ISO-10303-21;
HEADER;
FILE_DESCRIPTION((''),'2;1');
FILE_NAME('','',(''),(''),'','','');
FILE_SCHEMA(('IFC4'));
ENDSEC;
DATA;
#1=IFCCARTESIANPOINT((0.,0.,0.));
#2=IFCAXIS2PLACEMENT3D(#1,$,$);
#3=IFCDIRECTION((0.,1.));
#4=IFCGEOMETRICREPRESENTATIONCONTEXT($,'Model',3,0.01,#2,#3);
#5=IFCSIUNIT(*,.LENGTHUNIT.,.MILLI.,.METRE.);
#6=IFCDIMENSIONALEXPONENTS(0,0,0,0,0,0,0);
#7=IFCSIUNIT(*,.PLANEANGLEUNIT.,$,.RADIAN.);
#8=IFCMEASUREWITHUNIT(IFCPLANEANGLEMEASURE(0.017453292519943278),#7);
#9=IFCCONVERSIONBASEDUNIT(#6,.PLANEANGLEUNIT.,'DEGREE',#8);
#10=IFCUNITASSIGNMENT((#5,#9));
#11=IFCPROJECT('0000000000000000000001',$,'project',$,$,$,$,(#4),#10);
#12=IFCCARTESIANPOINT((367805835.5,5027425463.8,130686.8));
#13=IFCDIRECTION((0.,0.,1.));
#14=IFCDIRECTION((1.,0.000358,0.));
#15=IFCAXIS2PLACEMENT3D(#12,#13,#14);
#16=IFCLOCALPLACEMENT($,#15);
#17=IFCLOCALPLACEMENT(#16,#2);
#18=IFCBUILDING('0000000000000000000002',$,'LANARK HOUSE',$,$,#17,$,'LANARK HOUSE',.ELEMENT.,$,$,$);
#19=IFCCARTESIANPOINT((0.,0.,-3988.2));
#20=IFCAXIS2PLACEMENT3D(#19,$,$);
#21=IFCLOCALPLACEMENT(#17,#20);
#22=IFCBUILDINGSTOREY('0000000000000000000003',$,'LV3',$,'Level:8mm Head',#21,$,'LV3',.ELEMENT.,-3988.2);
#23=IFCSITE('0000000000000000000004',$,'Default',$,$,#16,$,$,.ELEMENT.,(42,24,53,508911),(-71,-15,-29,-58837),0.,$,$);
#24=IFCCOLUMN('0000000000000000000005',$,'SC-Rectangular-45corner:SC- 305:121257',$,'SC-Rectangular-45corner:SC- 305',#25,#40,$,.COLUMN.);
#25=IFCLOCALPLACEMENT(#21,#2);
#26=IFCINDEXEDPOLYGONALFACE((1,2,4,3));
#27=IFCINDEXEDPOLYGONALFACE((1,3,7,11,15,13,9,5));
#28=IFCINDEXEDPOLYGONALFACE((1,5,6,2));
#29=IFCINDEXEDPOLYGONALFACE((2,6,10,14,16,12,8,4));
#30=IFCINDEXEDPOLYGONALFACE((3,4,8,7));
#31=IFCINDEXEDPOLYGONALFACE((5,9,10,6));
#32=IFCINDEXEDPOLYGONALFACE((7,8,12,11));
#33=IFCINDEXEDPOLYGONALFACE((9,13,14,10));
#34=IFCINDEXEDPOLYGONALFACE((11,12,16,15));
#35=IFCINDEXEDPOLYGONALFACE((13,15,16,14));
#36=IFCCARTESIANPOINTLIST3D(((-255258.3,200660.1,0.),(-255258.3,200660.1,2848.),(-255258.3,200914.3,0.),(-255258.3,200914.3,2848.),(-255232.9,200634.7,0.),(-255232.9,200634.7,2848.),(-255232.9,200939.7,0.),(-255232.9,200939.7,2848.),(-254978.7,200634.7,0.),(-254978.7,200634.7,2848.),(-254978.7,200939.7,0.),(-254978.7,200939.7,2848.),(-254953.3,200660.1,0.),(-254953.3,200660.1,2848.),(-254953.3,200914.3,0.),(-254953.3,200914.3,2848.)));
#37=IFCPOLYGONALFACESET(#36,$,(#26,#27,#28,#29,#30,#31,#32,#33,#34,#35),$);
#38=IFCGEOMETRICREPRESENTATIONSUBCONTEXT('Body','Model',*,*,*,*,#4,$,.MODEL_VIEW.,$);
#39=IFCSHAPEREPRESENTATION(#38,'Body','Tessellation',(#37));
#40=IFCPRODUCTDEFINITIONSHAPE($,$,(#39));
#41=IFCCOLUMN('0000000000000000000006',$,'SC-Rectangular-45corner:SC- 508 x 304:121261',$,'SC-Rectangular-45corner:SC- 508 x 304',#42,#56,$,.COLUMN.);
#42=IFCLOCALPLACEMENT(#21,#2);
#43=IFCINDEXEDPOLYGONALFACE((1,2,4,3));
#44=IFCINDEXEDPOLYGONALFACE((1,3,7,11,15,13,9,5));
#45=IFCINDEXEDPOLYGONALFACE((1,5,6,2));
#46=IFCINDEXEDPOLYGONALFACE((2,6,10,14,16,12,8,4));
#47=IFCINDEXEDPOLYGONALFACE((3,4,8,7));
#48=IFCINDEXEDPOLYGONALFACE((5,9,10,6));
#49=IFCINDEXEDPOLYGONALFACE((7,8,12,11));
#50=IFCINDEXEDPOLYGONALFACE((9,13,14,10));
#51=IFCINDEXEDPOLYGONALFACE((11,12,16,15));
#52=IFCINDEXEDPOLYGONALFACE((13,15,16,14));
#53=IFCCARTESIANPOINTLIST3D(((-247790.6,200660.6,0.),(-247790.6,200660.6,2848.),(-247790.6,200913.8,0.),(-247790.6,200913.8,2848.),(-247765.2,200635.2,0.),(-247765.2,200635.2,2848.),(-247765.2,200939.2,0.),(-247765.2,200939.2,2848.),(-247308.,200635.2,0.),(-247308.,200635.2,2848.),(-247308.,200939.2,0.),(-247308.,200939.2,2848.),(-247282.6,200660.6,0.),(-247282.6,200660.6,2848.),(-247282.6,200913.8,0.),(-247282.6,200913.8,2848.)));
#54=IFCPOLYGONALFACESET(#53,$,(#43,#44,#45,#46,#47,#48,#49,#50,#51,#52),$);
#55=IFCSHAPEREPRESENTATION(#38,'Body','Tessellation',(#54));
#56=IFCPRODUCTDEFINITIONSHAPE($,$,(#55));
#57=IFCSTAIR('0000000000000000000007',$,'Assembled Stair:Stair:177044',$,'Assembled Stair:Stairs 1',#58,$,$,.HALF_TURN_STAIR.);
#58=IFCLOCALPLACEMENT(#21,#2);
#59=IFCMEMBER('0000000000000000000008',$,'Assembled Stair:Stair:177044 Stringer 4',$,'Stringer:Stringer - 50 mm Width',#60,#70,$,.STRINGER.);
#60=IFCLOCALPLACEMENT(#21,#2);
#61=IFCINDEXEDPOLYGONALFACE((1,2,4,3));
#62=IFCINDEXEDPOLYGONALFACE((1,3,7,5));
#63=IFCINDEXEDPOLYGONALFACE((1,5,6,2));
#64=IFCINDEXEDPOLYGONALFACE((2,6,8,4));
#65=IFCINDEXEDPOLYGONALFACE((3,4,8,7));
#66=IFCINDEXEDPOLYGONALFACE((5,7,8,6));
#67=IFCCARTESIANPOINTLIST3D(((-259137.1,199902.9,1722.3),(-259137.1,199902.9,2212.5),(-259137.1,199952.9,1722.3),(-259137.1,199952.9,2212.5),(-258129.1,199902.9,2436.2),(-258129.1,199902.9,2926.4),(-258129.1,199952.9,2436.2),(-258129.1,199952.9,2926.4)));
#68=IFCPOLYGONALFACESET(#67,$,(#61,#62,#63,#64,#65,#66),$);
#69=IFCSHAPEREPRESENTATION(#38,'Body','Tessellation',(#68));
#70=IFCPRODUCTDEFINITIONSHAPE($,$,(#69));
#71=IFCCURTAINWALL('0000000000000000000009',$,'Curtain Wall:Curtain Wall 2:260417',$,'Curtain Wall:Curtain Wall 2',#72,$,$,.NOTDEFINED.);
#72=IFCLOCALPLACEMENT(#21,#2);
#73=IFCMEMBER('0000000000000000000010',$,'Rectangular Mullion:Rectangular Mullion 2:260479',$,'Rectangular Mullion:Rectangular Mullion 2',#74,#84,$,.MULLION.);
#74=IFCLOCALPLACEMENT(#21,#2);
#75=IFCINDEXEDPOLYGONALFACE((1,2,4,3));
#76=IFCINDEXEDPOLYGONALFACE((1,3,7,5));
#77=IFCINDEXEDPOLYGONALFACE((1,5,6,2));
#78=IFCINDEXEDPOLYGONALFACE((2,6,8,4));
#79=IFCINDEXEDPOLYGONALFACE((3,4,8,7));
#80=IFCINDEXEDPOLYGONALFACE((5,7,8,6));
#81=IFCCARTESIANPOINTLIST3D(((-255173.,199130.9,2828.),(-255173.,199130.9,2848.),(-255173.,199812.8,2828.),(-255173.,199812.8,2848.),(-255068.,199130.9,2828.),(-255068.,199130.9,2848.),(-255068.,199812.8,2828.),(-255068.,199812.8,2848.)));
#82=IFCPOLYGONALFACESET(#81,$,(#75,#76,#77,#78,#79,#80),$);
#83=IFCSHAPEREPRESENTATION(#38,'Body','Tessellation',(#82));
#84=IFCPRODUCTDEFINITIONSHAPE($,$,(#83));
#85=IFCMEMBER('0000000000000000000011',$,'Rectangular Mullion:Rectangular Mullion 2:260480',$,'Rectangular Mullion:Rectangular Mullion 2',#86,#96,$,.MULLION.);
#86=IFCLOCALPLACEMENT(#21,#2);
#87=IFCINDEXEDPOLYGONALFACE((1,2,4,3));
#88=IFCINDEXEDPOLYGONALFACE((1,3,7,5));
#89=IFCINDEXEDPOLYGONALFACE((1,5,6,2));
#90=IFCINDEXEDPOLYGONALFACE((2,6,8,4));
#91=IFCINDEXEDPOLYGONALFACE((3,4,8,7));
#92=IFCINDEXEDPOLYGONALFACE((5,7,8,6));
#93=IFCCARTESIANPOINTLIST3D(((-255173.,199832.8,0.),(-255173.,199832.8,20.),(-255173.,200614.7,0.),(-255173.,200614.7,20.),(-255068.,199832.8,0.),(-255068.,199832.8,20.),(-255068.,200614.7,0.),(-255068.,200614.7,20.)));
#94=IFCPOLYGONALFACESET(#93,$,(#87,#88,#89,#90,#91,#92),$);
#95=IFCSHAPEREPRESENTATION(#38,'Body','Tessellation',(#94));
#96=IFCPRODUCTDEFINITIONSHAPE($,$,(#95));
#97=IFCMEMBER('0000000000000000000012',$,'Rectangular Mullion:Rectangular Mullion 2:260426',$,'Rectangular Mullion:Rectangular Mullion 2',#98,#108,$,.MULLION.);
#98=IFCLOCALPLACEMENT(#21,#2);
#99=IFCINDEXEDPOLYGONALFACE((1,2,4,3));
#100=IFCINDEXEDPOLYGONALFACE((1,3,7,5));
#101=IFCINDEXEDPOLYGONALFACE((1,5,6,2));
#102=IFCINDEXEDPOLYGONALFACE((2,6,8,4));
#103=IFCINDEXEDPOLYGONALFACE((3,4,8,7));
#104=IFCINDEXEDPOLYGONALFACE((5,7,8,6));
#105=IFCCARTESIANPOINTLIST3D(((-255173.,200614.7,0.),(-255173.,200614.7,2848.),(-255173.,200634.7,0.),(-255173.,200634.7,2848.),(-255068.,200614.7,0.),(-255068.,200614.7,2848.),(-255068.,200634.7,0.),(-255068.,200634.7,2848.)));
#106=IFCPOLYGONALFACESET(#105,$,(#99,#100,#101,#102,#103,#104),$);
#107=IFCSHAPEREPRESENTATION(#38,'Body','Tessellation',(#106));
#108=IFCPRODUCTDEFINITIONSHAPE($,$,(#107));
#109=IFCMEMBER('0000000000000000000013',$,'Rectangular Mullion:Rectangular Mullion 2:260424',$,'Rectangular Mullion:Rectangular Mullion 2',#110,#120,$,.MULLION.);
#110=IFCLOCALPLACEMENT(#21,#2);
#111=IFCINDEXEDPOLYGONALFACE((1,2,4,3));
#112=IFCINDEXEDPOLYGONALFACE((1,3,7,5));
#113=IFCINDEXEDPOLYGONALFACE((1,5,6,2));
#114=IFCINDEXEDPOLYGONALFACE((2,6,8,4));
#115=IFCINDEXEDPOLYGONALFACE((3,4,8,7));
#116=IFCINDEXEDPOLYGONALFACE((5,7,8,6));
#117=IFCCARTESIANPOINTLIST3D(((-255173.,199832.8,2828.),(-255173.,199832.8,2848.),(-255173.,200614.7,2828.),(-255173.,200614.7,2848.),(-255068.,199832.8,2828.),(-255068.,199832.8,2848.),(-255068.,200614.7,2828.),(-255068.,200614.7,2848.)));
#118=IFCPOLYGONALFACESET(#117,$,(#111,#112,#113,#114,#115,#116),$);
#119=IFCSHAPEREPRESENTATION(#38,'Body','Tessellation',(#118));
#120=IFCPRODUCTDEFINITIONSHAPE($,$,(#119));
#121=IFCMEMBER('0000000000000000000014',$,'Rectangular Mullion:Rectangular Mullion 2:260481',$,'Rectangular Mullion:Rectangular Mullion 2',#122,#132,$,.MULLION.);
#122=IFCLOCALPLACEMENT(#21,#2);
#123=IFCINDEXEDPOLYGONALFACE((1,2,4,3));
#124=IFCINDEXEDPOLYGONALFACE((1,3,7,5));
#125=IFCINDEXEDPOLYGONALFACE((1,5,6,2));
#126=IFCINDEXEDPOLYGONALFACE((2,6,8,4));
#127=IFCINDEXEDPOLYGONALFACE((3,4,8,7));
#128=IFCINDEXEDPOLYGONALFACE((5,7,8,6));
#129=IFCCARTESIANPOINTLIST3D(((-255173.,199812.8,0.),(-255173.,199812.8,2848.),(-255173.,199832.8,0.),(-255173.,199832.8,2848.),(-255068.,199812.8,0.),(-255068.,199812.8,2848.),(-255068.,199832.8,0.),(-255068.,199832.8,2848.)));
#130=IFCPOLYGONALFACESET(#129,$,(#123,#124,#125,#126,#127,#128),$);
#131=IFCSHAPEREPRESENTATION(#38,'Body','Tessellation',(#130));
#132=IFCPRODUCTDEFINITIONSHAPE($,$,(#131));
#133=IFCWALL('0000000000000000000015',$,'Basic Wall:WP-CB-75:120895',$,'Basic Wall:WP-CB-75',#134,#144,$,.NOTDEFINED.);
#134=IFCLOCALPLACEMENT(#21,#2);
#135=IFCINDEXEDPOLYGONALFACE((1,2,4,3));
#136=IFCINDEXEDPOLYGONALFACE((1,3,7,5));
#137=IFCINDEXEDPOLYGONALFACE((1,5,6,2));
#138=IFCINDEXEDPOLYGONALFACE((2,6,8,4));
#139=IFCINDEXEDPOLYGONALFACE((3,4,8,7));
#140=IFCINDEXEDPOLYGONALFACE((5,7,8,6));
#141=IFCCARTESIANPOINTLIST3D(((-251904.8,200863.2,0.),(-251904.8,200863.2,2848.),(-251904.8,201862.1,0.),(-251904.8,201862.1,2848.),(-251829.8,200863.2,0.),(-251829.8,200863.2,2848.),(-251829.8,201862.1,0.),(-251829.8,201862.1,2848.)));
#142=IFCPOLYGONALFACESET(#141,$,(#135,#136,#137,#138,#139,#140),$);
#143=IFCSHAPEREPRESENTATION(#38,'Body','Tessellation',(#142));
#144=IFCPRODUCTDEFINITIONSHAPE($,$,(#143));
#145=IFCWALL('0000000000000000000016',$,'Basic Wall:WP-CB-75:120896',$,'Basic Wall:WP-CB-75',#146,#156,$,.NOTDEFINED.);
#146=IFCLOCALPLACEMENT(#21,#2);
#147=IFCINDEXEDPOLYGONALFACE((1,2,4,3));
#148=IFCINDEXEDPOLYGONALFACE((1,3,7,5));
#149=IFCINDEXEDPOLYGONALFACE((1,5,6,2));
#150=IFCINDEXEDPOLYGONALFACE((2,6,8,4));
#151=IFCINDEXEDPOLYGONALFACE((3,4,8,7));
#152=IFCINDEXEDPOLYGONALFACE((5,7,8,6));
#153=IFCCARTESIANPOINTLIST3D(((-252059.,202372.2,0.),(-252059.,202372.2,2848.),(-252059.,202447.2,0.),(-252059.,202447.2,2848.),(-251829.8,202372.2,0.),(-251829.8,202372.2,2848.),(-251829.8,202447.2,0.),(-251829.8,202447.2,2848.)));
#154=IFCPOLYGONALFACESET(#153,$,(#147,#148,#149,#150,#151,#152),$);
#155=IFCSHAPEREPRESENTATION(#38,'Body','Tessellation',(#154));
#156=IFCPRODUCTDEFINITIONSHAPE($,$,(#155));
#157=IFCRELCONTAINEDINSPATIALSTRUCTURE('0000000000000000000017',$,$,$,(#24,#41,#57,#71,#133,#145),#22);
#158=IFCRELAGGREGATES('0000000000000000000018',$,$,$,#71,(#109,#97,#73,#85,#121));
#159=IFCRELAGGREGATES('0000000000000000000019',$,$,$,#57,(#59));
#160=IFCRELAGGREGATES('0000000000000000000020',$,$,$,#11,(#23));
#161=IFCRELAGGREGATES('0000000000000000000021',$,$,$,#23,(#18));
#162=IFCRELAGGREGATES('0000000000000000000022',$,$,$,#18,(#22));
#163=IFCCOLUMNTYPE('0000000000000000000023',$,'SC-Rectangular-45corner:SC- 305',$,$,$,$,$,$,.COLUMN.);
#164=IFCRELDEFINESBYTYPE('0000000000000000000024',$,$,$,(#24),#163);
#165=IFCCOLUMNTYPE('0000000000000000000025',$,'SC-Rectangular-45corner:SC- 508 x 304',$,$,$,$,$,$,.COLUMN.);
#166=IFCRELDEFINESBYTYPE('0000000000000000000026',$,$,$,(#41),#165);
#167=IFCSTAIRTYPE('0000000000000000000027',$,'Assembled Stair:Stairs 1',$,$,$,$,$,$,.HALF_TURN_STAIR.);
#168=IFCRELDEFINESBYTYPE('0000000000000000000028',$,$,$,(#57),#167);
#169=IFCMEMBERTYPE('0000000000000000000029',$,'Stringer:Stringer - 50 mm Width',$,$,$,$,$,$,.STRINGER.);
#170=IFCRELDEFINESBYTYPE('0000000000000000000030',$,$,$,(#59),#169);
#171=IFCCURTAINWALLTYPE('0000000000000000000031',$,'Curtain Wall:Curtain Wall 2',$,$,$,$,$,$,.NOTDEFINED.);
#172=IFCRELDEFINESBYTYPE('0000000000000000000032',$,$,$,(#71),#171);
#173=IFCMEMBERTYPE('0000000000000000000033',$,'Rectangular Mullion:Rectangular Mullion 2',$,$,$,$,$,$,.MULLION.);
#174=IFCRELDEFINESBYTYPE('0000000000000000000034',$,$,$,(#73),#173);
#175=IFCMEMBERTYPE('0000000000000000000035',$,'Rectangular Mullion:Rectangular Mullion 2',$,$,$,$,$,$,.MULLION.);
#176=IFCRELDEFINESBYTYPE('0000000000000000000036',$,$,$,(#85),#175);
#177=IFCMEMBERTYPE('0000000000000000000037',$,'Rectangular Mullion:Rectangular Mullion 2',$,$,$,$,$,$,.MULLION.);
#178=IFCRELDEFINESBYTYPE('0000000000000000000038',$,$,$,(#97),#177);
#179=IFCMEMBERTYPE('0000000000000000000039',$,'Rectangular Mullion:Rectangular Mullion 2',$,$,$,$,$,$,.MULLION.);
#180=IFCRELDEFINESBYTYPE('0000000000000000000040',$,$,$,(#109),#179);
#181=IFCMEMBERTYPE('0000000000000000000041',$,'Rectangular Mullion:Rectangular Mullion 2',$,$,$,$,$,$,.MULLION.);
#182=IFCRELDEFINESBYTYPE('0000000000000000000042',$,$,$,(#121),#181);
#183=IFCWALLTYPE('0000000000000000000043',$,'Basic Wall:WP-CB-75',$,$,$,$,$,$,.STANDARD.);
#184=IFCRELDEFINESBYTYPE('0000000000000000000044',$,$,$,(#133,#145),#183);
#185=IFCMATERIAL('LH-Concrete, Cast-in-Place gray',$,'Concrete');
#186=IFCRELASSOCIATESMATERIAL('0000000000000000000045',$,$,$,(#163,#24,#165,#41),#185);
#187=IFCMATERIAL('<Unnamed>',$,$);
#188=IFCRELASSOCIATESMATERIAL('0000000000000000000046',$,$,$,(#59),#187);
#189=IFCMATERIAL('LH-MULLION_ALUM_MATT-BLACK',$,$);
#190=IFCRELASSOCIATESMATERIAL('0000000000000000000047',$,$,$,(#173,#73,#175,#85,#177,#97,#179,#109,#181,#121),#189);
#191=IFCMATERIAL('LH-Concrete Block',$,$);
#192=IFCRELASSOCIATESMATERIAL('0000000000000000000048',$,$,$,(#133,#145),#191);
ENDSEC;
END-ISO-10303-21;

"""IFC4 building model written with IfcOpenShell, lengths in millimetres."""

from ifc_helpers import new_model, entity, si_unit, converted_unit, direction, frame, origin, place, context, subcontext, project, spatial, indexed_curve, outline, extrude, source, transform, mapped, material, type_object, type_shapes, element, aggregate, save


model = new_model("IFC4")

# Units and contexts
model_context = context("Model", 3, precision=0.01, world=origin(), true_north=direction((0.0, 1.0)))
body_context = subcontext(model_context, "Body", "Model", "MODEL_VIEW")
ifc_project = project(units=[si_unit("LENGTHUNIT", "METRE", prefix="MILLI"), converted_unit("PLANEANGLEUNIT", "DEGREE", entity("IfcPlaneAngleMeasure", 0.017453292519943278), si_unit("PLANEANGLEUNIT", "RADIAN"), dimensions=[0, 0, 0, 0, 0, 0, 0])], contexts=[model_context])

# Site, building, storey
site_placement = place(None, frame((367805835.5, 5027425463.8, 130686.8), z_axis=(0.0, 0.0, 1.0), x_axis=(1.0, 0.000358, 0.0)))
site = spatial("IfcSite", under=ifc_project, at=site_placement, Name="Default", CompositionType="ELEMENT", RefLatitude=(42, 24, 53, 508911), RefLongitude=(-71, -15, -29, -58837), RefElevation=0.0)
building_placement = place(site_placement, origin())
building = spatial("IfcBuilding", under=site, at=building_placement, Name="LANARK HOUSE", LongName="LANARK HOUSE", CompositionType="ELEMENT")
storey_placement = place(building_placement, frame((0.0, 0.0, -3988.2)))
storey = spatial("IfcBuildingStorey", under=building, at=storey_placement, Name="LV3", ObjectType="Level:8mm Head", LongName="LV3", CompositionType="ELEMENT", Elevation=-3988.2)

# Columns
ifc_material_1 = material(Name="LH-Concrete, Cast-in-Place gray", Category="Concrete")
column_type_1 = type_object("IfcColumnType", Name="SC-Rectangular-45corner:SC- 305", PredefinedType="COLUMN", material=ifc_material_1)
shared_shape_1 = source(origin(), body_context, "Body", "SweptSolid", [
    extrude(outline(indexed_curve([(-127.1, -152.5), (127.1, -152.5), (152.5, -127.1), (152.5, 127.1), (127.1, 152.5), (-127.1, 152.5), (-152.5, 127.1), (-152.5, -127.1), (-127.1, -152.5)], self_intersect=False)), frame((0.0, 0.0, -3988.2), z_axis=(0.0, 0.0, 1.0), x_axis=(-1.0, 0.0, 0.0)), (0.0, 0.0, 1.0), 2848.0),
])
type_shapes(column_type_1, [shared_shape_1])
column_1_placement = place(storey_placement, frame((-255105.8, 200787.2, 3988.2)))
element("IfcColumn", 1, at=column_1_placement, inside=storey, type_object=column_type_1, material=ifc_material_1, Name="SC-Rectangular-45corner:SC- 305:121257", ObjectType="SC-Rectangular-45corner:SC- 305", PredefinedType="COLUMN", context=body_context, shape_type="MappedRepresentation", body=[
    mapped(shared_shape_1, transform((0.0, 0.0, 0.0), scale=1.0)),
])
column_type_2 = type_object("IfcColumnType", Name="SC-Rectangular-45corner:SC- 508 x 304", PredefinedType="COLUMN", material=ifc_material_1)
shared_shape_2 = source(origin(), body_context, "Body", "SweptSolid", [
    extrude(outline(indexed_curve([(-228.6, -152.0), (228.6, -152.0), (254.0, -126.6), (254.0, 126.6), (228.6, 152.0), (-228.6, 152.0), (-254.0, 126.6), (-254.0, -126.6), (-228.6, -152.0)], self_intersect=False)), frame((0.0, 0.0, -3988.2), z_axis=(0.0, 0.0, 1.0), x_axis=(-1.0, 0.0, 0.0)), (0.0, 0.0, 1.0), 2848.0),
])
type_shapes(column_type_2, [shared_shape_2])
column_2_placement = place(storey_placement, frame((-247536.6, 200787.2, 3988.2)))
element("IfcColumn", 2, at=column_2_placement, inside=storey, type_object=column_type_2, material=ifc_material_1, Name="SC-Rectangular-45corner:SC- 508 x 304:121261", ObjectType="SC-Rectangular-45corner:SC- 508 x 304", PredefinedType="COLUMN", context=body_context, shape_type="MappedRepresentation", body=[
    mapped(shared_shape_2, transform((0.0, 0.0, 0.0), scale=1.0)),
])

# Stair, member
stair_type = type_object("IfcStairType", Name="Assembled Stair:Stairs 1", PredefinedType="HALF_TURN_STAIR")
stair_placement = place(storey_placement, origin())
stair = element("IfcStair", 3, at=stair_placement, inside=storey, type_object=stair_type, Name="Assembled Stair:Stair:177044", ObjectType="Assembled Stair:Stairs 1", PredefinedType="HALF_TURN_STAIR")
ifc_material_2 = material(Name="<Unnamed>")
member_type_1 = type_object("IfcMemberType", Name="Stringer:Stringer - 50 mm Width", PredefinedType="STRINGER")
member_1_placement = place(stair_placement, frame((-259137.1, 199902.9, 1722.3)))
member_1 = element("IfcMember", 4, at=member_1_placement, type_object=member_type_1, material=ifc_material_2, Name="Assembled Stair:Stair:177044 Stringer 4", ObjectType="Stringer:Stringer - 50 mm Width", PredefinedType="STRINGER", context=body_context, shape_type="SweptSolid", body=[
    extrude(outline(indexed_curve([(-476.0, -200.0), (759.2, -200.0), (476.0, 200.0), (-759.2, 200.0), (-476.0, -200.0)], self_intersect=False)), frame((504.0, 0.0, 602.0), z_axis=(0.0, 1.0, 0.0), x_axis=(0.816066, 0.0, 0.577959)), (0.0, 0.0, 1.0), 50.0),
])

# Curtain wall, members
curtain_wall_type = type_object("IfcCurtainWallType", Name="Curtain Wall:Curtain Wall 2", PredefinedType="NOTDEFINED")
curtain_wall_placement = place(storey_placement, frame((0.0, 0.0, 3988.2)))
curtain_wall = element("IfcCurtainWall", 5, at=curtain_wall_placement, inside=storey, type_object=curtain_wall_type, Name="Curtain Wall:Curtain Wall 2:260417", ObjectType="Curtain Wall:Curtain Wall 2", PredefinedType="NOTDEFINED")
ifc_material_3 = material(Name="LH-MULLION_ALUM_MATT-BLACK")
member_type_2 = type_object("IfcMemberType", Name="Rectangular Mullion:Rectangular Mullion 2", PredefinedType="MULLION", material=ifc_material_3)
shared_shape_3 = source(origin(), body_context, "Body", "SweptSolid", [
    extrude(outline(indexed_curve([(-10.0, -52.5), (10.0, -52.5), (10.0, 52.5), (-10.0, 52.5), (-10.0, -52.5)], self_intersect=False)), frame((-10.0, -40.0, -681.9), z_axis=(0.0, 0.0, 1.0), x_axis=(-1.0, 0.0, 0.0)), (0.0, 0.0, 1.0), 681.9),
])
type_shapes(member_type_2, [shared_shape_3])
member_2_placement = place(curtain_wall_placement, frame((-255080.5, 199812.8, -1140.2), z_axis=(0.0, 1.0, 0.0), x_axis=(0.0, 0.0, 1.0)))
member_2 = element("IfcMember", 6, at=member_2_placement, type_object=member_type_2, material=ifc_material_3, Name="Rectangular Mullion:Rectangular Mullion 2:260479", ObjectType="Rectangular Mullion:Rectangular Mullion 2", PredefinedType="MULLION", context=body_context, shape_type="MappedRepresentation", body=[
    mapped(shared_shape_3, transform((0.0, 0.0, 0.0), scale=1.0)),
])
member_type_3 = type_object("IfcMemberType", Name="Rectangular Mullion:Rectangular Mullion 2", PredefinedType="MULLION", material=ifc_material_3)
shared_shape_4 = source(origin(), body_context, "Body", "SweptSolid", [
    extrude(outline(indexed_curve([(-10.0, -52.5), (10.0, -52.5), (10.0, 52.5), (-10.0, 52.5), (-10.0, -52.5)], self_intersect=False)), frame((-10.0, -40.0, -781.9), z_axis=(0.0, 0.0, 1.0), x_axis=(-1.0, 0.0, 0.0)), (0.0, 0.0, 1.0), 781.9),
])
type_shapes(member_type_3, [shared_shape_4])
member_3_placement = place(curtain_wall_placement, frame((-255080.5, 199832.8, -3988.2), z_axis=(0.0, -1.0, 0.0), x_axis=(0.0, 0.0, -1.0)))
member_3 = element("IfcMember", 7, at=member_3_placement, type_object=member_type_3, material=ifc_material_3, Name="Rectangular Mullion:Rectangular Mullion 2:260480", ObjectType="Rectangular Mullion:Rectangular Mullion 2", PredefinedType="MULLION", context=body_context, shape_type="MappedRepresentation", body=[
    mapped(shared_shape_4, transform((0.0, 0.0, 0.0), scale=1.0)),
])
member_type_4 = type_object("IfcMemberType", Name="Rectangular Mullion:Rectangular Mullion 2", PredefinedType="MULLION", material=ifc_material_3)
shared_shape_5 = source(origin(), body_context, "Body", "SweptSolid", [
    extrude(outline(indexed_curve([(-10.0, -52.5), (10.0, -52.5), (10.0, 52.5), (-10.0, 52.5), (-10.0, -52.5)], self_intersect=False)), frame((-10.0, -40.0, -2848.0), z_axis=(0.0, 0.0, 1.0), x_axis=(-1.0, 0.0, 0.0)), (0.0, 0.0, 1.0), 2848.0),
])
type_shapes(member_type_4, [shared_shape_5])
member_4_placement = place(curtain_wall_placement, frame((-255080.5, 200634.7, -3988.2), z_axis=(0.0, 0.0, -1.0), x_axis=(0.0, 1.0, 0.0)))
member_4 = element("IfcMember", 8, at=member_4_placement, type_object=member_type_4, material=ifc_material_3, Name="Rectangular Mullion:Rectangular Mullion 2:260426", ObjectType="Rectangular Mullion:Rectangular Mullion 2", PredefinedType="MULLION", context=body_context, shape_type="MappedRepresentation", body=[
    mapped(shared_shape_5, transform((0.0, 0.0, 0.0), scale=1.0)),
])
member_type_5 = type_object("IfcMemberType", Name="Rectangular Mullion:Rectangular Mullion 2", PredefinedType="MULLION", material=ifc_material_3)
shared_shape_6 = source(origin(), body_context, "Body", "SweptSolid", [
    extrude(outline(indexed_curve([(-10.0, -52.5), (10.0, -52.5), (10.0, 52.5), (-10.0, 52.5), (-10.0, -52.5)], self_intersect=False)), frame((-10.0, -40.0, -781.9), z_axis=(0.0, 0.0, 1.0), x_axis=(-1.0, 0.0, 0.0)), (0.0, 0.0, 1.0), 781.9),
])
type_shapes(member_type_5, [shared_shape_6])
member_5_placement = place(curtain_wall_placement, frame((-255080.5, 200614.7, -1140.2), z_axis=(0.0, 1.0, 0.0), x_axis=(0.0, 0.0, 1.0)))
member_5 = element("IfcMember", 9, at=member_5_placement, type_object=member_type_5, material=ifc_material_3, Name="Rectangular Mullion:Rectangular Mullion 2:260424", ObjectType="Rectangular Mullion:Rectangular Mullion 2", PredefinedType="MULLION", context=body_context, shape_type="MappedRepresentation", body=[
    mapped(shared_shape_6, transform((0.0, 0.0, 0.0), scale=1.0)),
])
member_type_6 = type_object("IfcMemberType", Name="Rectangular Mullion:Rectangular Mullion 2", PredefinedType="MULLION", material=ifc_material_3)
shared_shape_7 = source(origin(), body_context, "Body", "SweptSolid", [
    extrude(outline(indexed_curve([(-10.0, -52.5), (10.0, -52.5), (10.0, 52.5), (-10.0, 52.5), (-10.0, -52.5)], self_intersect=False)), frame((0.0, -40.0, -2848.0), z_axis=(0.0, 0.0, 1.0), x_axis=(-1.0, 0.0, 0.0)), (0.0, 0.0, 1.0), 2848.0),
])
type_shapes(member_type_6, [shared_shape_7])
member_6_placement = place(curtain_wall_placement, frame((-255080.5, 199822.8, -3988.2), z_axis=(0.0, 0.0, -1.0), x_axis=(0.0, 1.0, 0.0)))
member_6 = element("IfcMember", 10, at=member_6_placement, type_object=member_type_6, material=ifc_material_3, Name="Rectangular Mullion:Rectangular Mullion 2:260481", ObjectType="Rectangular Mullion:Rectangular Mullion 2", PredefinedType="MULLION", context=body_context, shape_type="MappedRepresentation", body=[
    mapped(shared_shape_7, transform((0.0, 0.0, 0.0), scale=1.0)),
])

# Walls
ifc_material_4 = material(Name="LH-Concrete Block")
wall_type_1 = type_object("IfcWallType", Name="Basic Wall:WP-CB-75", PredefinedType="STANDARD")
wall_1_placement = place(storey_placement, frame((-251867.3, 200863.2, 0.0), z_axis=(0.0, 0.0, 1.0), x_axis=(0.0, 1.0, 0.0)))
element("IfcWall", 11, at=wall_1_placement, inside=storey, type_object=wall_type_1, material=ifc_material_4, Name="Basic Wall:WP-CB-75:120895", ObjectType="Basic Wall:WP-CB-75", PredefinedType="NOTDEFINED", context=body_context, shape_type="SweptSolid", body=[
    extrude(outline(indexed_curve([(998.9, 37.5), (0.0, 37.5), (0.0, -37.5), (998.9, -37.5), (998.9, 37.5)], self_intersect=False)), origin(), (0.0, 0.0, 1.0), 2848.0),
])
wall_2_placement = place(storey_placement, frame((-252059.0, 202409.7, 0.0)))
element("IfcWall", 12, at=wall_2_placement, inside=storey, type_object=wall_type_1, material=ifc_material_4, Name="Basic Wall:WP-CB-75:120896", ObjectType="Basic Wall:WP-CB-75", PredefinedType="NOTDEFINED", context=body_context, shape_type="SweptSolid", body=[
    extrude(outline(indexed_curve([(229.2, 37.5), (0.0, 37.5), (0.0, -37.5), (229.2, -37.5), (229.2, 37.5)], self_intersect=False)), origin(), (0.0, 0.0, 1.0), 2848.0),
])

aggregate(curtain_wall, [member_5, member_4, member_2, member_3, member_6])

aggregate(stair, [member_1])

save(model, "model.ifc")
